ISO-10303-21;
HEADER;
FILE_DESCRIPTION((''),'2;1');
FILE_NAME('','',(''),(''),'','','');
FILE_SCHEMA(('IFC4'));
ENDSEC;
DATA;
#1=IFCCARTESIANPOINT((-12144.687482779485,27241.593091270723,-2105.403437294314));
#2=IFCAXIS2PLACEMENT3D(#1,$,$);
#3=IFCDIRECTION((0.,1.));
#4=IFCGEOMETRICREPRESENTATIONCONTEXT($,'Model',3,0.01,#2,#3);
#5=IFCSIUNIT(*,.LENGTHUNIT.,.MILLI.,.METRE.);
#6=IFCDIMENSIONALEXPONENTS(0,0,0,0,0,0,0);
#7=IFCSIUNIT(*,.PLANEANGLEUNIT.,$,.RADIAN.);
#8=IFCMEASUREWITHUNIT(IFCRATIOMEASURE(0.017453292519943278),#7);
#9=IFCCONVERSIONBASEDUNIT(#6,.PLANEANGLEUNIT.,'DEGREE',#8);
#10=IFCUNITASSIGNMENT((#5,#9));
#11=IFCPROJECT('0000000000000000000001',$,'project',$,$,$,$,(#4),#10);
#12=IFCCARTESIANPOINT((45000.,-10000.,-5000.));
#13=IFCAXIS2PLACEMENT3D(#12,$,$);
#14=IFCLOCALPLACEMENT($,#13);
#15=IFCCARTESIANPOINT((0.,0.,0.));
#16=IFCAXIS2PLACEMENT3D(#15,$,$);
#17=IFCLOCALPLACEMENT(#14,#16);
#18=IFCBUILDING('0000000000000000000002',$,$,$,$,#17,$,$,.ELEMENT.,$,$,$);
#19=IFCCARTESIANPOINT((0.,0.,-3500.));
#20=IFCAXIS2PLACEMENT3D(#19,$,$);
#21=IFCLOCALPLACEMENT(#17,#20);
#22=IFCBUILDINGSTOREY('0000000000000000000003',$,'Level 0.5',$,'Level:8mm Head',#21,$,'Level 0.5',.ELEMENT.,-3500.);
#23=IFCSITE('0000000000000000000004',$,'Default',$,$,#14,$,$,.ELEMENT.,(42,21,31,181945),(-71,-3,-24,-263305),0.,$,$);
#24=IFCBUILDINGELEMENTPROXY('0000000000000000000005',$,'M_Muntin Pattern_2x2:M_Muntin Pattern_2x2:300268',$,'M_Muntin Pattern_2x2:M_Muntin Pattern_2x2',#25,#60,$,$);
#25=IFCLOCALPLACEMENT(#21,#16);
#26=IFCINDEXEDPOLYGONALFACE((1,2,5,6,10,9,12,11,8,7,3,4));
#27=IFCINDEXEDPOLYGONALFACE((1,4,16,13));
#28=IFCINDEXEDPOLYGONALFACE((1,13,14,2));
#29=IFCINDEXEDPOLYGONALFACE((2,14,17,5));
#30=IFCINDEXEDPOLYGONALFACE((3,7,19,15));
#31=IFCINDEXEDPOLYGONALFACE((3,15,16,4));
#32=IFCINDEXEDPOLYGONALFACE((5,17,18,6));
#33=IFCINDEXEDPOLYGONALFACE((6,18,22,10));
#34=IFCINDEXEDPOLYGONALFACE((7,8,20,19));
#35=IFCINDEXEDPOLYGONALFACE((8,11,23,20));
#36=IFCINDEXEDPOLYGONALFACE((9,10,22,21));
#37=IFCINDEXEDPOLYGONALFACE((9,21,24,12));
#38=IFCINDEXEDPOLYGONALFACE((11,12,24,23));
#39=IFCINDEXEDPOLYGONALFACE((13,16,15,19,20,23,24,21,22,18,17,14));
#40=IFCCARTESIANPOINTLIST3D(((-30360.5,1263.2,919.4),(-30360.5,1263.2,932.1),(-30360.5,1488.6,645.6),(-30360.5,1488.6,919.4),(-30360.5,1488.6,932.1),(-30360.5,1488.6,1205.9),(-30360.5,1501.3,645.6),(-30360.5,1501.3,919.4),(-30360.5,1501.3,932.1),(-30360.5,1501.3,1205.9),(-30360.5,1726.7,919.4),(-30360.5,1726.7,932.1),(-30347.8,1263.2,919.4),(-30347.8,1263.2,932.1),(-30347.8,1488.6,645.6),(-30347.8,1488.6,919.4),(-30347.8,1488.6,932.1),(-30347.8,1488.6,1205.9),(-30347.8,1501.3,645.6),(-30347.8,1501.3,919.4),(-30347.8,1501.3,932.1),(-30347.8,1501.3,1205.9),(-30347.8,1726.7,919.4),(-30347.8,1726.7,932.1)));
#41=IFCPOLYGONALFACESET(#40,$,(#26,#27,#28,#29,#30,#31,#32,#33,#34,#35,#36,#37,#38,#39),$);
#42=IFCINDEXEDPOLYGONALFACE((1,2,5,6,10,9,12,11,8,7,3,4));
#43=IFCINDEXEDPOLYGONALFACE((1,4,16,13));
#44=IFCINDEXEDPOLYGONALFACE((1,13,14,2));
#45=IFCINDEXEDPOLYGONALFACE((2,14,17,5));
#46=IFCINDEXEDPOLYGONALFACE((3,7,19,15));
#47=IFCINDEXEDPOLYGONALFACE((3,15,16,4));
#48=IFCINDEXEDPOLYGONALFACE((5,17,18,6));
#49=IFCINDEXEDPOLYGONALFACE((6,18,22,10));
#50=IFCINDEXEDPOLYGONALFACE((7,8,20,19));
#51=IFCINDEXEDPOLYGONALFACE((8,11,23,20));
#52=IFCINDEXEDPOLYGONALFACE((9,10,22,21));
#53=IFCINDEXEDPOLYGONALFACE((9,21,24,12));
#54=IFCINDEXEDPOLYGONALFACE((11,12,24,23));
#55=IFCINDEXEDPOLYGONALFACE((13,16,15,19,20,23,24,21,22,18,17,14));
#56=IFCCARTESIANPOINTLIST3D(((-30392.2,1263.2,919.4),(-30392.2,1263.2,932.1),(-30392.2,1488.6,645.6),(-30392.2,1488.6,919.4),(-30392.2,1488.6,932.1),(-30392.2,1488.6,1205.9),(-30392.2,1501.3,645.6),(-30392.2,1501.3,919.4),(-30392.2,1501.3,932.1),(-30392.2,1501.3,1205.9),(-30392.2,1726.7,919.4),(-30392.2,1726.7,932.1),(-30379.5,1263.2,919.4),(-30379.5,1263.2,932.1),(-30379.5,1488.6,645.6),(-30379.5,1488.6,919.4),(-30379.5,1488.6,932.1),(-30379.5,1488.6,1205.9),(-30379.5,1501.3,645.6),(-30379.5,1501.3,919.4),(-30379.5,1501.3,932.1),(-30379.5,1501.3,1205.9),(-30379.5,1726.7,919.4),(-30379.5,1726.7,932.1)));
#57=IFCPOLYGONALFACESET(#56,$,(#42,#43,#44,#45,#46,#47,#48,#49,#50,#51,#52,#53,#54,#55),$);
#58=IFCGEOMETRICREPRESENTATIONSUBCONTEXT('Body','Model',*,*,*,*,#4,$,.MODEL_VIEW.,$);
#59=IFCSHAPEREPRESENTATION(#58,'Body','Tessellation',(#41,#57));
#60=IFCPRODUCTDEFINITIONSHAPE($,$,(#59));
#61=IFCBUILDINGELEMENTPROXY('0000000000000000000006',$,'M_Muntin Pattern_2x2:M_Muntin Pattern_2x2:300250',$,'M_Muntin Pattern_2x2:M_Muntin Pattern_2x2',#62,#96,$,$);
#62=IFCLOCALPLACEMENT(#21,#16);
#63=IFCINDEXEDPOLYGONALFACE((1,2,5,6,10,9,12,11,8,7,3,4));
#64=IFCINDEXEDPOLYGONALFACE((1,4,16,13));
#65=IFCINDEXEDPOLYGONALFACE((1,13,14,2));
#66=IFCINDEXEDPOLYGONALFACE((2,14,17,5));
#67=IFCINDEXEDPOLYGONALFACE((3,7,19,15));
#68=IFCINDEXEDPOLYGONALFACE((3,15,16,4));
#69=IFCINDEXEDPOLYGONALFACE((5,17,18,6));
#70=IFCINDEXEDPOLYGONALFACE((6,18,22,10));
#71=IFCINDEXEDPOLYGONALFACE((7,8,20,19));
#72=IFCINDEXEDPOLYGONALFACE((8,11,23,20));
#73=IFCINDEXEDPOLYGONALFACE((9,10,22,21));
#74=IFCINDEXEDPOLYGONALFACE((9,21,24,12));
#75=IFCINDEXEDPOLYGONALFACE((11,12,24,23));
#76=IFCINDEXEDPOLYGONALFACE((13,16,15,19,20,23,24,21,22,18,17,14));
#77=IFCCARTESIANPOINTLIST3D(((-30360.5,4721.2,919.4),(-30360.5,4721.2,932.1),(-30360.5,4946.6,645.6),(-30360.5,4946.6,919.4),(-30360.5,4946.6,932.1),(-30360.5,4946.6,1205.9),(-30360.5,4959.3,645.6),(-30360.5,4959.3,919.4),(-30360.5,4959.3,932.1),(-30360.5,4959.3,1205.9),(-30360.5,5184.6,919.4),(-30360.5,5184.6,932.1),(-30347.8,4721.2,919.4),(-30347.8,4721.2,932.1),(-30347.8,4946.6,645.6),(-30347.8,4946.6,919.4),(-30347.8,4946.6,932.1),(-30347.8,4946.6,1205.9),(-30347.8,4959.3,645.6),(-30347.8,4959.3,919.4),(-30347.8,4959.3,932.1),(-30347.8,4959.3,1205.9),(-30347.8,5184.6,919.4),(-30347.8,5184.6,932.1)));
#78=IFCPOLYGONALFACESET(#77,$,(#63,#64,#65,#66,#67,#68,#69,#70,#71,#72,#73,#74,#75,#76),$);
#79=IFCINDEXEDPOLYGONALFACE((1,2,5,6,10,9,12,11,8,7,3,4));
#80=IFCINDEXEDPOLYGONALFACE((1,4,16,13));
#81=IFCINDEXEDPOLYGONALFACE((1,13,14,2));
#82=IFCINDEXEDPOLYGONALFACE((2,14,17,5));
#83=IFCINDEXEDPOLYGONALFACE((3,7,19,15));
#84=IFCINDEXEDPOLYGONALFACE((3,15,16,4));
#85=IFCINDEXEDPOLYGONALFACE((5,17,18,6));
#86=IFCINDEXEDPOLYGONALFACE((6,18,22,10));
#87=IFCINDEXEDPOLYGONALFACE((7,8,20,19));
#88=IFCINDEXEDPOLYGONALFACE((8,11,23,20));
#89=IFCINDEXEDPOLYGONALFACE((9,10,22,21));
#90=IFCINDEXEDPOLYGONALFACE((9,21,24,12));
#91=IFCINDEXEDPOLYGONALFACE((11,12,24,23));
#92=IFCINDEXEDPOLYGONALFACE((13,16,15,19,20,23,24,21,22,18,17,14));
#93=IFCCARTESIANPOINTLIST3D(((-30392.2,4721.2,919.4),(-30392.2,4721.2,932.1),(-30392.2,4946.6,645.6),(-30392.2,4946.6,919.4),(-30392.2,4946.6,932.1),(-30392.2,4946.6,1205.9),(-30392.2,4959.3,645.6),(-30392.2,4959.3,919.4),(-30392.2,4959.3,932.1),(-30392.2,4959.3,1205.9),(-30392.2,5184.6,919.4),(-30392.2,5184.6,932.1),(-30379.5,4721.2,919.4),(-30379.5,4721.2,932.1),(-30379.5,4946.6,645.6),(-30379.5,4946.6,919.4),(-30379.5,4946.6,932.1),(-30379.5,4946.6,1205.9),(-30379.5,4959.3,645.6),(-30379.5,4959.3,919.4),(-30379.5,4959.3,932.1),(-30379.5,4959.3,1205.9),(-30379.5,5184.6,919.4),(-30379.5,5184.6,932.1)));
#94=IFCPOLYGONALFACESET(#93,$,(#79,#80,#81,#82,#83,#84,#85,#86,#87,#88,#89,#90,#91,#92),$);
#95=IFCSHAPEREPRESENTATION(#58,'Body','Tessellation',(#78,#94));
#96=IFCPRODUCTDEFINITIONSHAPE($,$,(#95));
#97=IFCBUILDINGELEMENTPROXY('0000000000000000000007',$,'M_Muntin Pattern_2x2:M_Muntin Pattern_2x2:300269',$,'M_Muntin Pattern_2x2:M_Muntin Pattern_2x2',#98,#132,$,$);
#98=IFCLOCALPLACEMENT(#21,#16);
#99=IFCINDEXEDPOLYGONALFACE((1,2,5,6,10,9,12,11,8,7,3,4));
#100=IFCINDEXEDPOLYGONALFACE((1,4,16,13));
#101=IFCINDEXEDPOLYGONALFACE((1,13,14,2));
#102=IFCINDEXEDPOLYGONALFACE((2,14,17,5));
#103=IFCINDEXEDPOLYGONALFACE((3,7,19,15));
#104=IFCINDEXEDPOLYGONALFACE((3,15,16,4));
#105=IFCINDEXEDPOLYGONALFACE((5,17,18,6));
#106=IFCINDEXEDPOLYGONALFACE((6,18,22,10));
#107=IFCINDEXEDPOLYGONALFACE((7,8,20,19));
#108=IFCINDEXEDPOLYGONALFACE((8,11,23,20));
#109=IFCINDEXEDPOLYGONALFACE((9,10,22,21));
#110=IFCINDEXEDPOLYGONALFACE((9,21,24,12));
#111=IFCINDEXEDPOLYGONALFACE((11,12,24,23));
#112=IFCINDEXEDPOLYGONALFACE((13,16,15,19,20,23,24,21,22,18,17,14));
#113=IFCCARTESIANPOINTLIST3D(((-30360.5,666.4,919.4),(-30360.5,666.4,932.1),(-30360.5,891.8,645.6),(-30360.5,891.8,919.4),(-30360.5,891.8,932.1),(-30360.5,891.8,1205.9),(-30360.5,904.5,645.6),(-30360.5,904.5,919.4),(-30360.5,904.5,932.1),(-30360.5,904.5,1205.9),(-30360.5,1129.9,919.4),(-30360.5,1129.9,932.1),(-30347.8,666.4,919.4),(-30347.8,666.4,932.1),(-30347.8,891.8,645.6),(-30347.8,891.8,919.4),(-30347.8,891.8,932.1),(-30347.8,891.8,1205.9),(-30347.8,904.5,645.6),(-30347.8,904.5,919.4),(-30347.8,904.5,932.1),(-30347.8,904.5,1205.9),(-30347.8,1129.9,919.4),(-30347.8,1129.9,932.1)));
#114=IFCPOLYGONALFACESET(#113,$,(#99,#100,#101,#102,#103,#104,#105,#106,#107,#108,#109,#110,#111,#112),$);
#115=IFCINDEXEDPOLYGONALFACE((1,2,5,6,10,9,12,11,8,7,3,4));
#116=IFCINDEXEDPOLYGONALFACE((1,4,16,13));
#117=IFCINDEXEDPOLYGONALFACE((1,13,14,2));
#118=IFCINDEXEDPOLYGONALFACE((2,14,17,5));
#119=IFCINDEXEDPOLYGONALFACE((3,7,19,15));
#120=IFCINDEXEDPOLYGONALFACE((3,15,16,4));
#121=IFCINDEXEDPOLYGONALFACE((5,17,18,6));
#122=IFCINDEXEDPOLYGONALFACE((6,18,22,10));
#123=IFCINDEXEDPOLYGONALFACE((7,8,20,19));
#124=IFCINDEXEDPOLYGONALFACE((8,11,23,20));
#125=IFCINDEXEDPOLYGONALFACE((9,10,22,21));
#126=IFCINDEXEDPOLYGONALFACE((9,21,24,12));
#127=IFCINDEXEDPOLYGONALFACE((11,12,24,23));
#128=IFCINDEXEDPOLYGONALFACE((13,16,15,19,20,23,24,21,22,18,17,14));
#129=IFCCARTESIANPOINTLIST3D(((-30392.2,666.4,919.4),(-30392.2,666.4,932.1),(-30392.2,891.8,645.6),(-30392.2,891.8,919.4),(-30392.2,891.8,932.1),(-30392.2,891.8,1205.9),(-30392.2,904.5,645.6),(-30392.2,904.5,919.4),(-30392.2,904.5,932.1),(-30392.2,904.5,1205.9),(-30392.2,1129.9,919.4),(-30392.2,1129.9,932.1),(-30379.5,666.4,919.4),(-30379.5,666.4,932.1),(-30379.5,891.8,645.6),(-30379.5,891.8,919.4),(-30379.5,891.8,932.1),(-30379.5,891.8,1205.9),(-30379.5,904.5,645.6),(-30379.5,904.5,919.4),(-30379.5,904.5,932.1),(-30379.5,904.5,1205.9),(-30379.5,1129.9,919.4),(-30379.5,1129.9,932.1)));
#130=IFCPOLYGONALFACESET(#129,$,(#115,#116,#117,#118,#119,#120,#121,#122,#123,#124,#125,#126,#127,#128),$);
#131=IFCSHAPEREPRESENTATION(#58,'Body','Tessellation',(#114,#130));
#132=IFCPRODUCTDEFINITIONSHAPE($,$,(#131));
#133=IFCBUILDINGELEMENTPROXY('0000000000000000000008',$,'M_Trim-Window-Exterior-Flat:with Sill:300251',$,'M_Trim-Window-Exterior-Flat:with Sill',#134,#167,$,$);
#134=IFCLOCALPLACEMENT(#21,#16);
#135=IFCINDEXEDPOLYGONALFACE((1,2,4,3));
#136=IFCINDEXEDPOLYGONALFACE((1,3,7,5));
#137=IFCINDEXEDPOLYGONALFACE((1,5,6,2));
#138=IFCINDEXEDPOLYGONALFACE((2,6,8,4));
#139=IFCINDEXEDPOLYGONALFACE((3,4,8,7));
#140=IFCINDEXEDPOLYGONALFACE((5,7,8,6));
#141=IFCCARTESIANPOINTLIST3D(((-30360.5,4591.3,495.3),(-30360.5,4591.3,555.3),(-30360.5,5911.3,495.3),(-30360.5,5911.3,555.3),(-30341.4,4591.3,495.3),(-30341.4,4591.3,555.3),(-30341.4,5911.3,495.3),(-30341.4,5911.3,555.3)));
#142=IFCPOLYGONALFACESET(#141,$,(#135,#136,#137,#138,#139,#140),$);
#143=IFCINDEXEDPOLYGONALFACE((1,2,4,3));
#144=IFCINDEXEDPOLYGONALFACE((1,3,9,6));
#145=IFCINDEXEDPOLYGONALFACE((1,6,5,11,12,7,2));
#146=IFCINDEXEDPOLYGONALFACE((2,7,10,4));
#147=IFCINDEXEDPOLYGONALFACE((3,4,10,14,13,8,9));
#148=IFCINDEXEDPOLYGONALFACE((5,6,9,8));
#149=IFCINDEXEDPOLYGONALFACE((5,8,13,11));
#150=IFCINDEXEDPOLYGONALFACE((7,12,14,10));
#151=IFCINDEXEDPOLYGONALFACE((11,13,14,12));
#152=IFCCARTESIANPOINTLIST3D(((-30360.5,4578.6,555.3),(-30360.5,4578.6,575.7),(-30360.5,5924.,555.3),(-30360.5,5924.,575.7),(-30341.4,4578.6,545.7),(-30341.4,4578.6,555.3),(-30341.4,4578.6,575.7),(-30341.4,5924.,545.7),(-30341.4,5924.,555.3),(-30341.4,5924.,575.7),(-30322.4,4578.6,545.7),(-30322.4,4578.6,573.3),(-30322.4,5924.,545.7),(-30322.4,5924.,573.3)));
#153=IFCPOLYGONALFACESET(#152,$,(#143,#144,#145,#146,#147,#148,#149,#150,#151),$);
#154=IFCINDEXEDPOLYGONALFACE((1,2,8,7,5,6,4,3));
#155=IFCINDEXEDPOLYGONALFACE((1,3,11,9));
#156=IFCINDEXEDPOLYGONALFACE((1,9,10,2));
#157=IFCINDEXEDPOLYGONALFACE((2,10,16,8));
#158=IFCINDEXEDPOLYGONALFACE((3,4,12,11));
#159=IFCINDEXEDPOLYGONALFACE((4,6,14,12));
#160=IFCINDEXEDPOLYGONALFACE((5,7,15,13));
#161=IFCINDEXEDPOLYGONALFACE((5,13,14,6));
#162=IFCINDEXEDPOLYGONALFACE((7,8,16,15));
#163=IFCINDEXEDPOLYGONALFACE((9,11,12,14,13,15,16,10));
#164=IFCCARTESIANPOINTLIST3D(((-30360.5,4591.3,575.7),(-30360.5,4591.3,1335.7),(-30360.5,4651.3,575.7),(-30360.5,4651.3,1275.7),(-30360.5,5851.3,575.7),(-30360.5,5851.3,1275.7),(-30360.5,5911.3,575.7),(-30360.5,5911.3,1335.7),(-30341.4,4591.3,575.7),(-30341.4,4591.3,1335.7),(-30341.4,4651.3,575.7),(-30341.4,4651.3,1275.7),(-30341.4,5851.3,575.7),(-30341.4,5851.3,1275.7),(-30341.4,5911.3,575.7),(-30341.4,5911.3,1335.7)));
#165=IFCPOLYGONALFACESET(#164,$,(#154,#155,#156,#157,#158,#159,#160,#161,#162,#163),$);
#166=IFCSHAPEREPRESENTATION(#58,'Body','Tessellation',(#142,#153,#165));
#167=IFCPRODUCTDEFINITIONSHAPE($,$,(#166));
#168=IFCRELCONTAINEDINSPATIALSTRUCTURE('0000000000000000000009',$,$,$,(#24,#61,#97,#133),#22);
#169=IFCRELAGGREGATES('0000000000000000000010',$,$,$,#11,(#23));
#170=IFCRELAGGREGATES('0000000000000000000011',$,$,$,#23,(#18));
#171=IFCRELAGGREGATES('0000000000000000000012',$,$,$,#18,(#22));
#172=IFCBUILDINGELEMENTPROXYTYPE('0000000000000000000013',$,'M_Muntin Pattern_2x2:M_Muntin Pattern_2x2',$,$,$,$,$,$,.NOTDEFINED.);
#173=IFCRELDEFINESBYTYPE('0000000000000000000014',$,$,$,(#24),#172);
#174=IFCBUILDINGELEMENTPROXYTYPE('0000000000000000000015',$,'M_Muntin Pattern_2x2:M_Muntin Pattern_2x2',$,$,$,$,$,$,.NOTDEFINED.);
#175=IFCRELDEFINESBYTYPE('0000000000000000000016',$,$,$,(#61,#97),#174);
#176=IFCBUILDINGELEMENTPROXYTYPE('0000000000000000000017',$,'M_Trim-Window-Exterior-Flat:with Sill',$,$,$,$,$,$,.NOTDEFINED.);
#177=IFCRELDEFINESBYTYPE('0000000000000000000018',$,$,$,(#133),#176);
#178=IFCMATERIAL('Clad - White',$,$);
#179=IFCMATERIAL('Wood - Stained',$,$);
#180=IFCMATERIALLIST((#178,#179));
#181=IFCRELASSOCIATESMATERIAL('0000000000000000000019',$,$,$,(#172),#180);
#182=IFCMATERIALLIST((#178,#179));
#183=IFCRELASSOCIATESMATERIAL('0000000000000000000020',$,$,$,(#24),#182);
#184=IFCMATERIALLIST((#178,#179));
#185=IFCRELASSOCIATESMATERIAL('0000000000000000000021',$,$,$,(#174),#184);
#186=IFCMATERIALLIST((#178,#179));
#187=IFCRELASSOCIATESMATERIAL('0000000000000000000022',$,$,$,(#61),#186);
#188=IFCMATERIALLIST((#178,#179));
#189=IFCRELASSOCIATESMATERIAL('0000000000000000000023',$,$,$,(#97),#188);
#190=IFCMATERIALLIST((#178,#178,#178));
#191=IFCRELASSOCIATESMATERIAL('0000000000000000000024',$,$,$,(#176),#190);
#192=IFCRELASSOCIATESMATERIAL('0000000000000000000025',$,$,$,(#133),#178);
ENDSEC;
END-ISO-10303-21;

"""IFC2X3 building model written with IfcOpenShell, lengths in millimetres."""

from ifc_helpers import new_model, entity, si_unit, converted_unit, direction, frame, frame_2d, origin, place, context, subcontext, project, spatial, polyline, rectangle, outline, extrude, source, transform, mapped, material, material_list, type_object, type_shapes, element, save


model = new_model("IFC2X3")

# Units and contexts
model_context = context("Model", 3, precision=0.01, world=frame((-12144.687482779485, 27241.593091270723, -2105.403437294314)), true_north=direction((0.0, 1.0)))
body_context = subcontext(model_context, "Body", "Model", "MODEL_VIEW")
ifc_project = project(units=[si_unit("LENGTHUNIT", "METRE", prefix="MILLI"), converted_unit("PLANEANGLEUNIT", "DEGREE", entity("IfcRatioMeasure", 0.017453292519943278), si_unit("PLANEANGLEUNIT", "RADIAN"), dimensions=[0, 0, 0, 0, 0, 0, 0])], contexts=[model_context])

# Site, building, storey
site_placement = place(None, frame((45000.0, -10000.0, -5000.0)))
site = spatial("IfcSite", under=ifc_project, at=site_placement, Name="Default", CompositionType="ELEMENT", RefLatitude=(42, 21, 31, 181945), RefLongitude=(-71, -3, -24, -263305), RefElevation=0.0)
building_placement = place(site_placement, origin())
building = spatial("IfcBuilding", under=site, at=building_placement, CompositionType="ELEMENT")
storey_placement = place(building_placement, frame((0.0, 0.0, -3500.0)))
storey = spatial("IfcBuildingStorey", under=building, at=storey_placement, Name="Level 0.5", ObjectType="Level:8mm Head", LongName="Level 0.5", CompositionType="ELEMENT", Elevation=-3500.0)

# Building element proxies
ifc_material_1 = material(Name="Clad - White")
ifc_material_2 = material(Name="Wood - Stained")
ifc_material_list_1 = material_list([ifc_material_1, ifc_material_2])
ifc_material_list_2 = material_list([ifc_material_1, ifc_material_2])
building_element_proxy_type_1 = type_object("IfcBuildingElementProxyType", Name="M_Muntin Pattern_2x2:M_Muntin Pattern_2x2", PredefinedType="NOTDEFINED", material=ifc_material_list_2)
shared_shape_1 = source(origin(), body_context, "Body", "SweptSolid", [
    extrude(outline(polyline([(6.4, -6.4), (280.1, -6.4), (280.1, 6.3), (6.4, 6.3), (6.4, 231.7), (-6.3, 231.7), (-6.3, 6.3), (-280.2, 6.3), (-280.2, -6.4), (-6.3, -6.4), (-6.3, -231.7), (6.4, -231.7), (6.4, -6.4)])), frame((0.0, 9.5, 280.1), z_axis=(0.0, 1.0, 0.0), x_axis=(0.0, 0.0, 1.0)), (0.0, 0.0, 1.0), 12.7),
    extrude(outline(polyline([(6.4, -6.4), (280.2, -6.4), (280.2, 6.3), (6.4, 6.3), (6.4, 231.7), (-6.3, 231.7), (-6.3, 6.3), (-280.2, 6.3), (-280.2, -6.4), (-6.3, -6.4), (-6.3, -231.7), (6.4, -231.7), (6.4, -6.4)])), frame((0.0, -22.2, 280.2), z_axis=(0.0, 1.0, 0.0), x_axis=(0.0, 0.0, 1.0)), (0.0, 0.0, 1.0), 12.7),
])
type_shapes(building_element_proxy_type_1, [shared_shape_1])
proxy_1_placement = place(storey_placement, frame((-30370.0, 1495.0, 645.6), z_axis=(0.0, 0.0, 1.0), x_axis=(0.0, -1.0, 0.0)))
element("IfcBuildingElementProxy", 1, at=proxy_1_placement, inside=storey, type_object=building_element_proxy_type_1, material=ifc_material_list_1, Name="M_Muntin Pattern_2x2:M_Muntin Pattern_2x2:300268", ObjectType="M_Muntin Pattern_2x2:M_Muntin Pattern_2x2", context=body_context, shape_type="MappedRepresentation", body=[
    mapped(shared_shape_1, transform((0.0, 0.0, 0.0), scale=1.0)),
])
ifc_material_list_3 = material_list([ifc_material_1, ifc_material_2])
ifc_material_list_4 = material_list([ifc_material_1, ifc_material_2])
building_element_proxy_type_2 = type_object("IfcBuildingElementProxyType", Name="M_Muntin Pattern_2x2:M_Muntin Pattern_2x2", PredefinedType="NOTDEFINED", material=ifc_material_list_4)
shared_shape_2 = source(origin(), body_context, "Body", "SweptSolid", [
    extrude(outline(polyline([(6.4, -6.4), (280.1, -6.4), (280.1, 6.3), (6.4, 6.3), (6.4, 231.7), (-6.3, 231.7), (-6.3, 6.3), (-280.2, 6.3), (-280.2, -6.4), (-6.3, -6.4), (-6.3, -231.7), (6.4, -231.7), (6.4, -6.4)])), frame((0.0, -22.2, 280.1), z_axis=(0.0, 1.0, 0.0), x_axis=(0.0, 0.0, 1.0)), (0.0, 0.0, 1.0), 12.7),
    extrude(outline(polyline([(6.4, -6.4), (280.2, -6.4), (280.2, 6.3), (6.4, 6.3), (6.4, 231.7), (-6.3, 231.7), (-6.3, 6.3), (-280.2, 6.3), (-280.2, -6.4), (-6.3, -6.4), (-6.3, -231.7), (6.4, -231.7), (6.4, -6.4)])), frame((0.0, 9.5, 280.2), z_axis=(0.0, 1.0, 0.0), x_axis=(0.0, 0.0, 1.0)), (0.0, 0.0, 1.0), 12.7),
])
type_shapes(building_element_proxy_type_2, [shared_shape_2])
proxy_2_placement = place(storey_placement, frame((-30370.0, 4952.9, 645.6), z_axis=(0.0, 0.0, 1.0), x_axis=(0.0, 1.0, 0.0)))
element("IfcBuildingElementProxy", 2, at=proxy_2_placement, inside=storey, type_object=building_element_proxy_type_2, material=ifc_material_list_3, Name="M_Muntin Pattern_2x2:M_Muntin Pattern_2x2:300250", ObjectType="M_Muntin Pattern_2x2:M_Muntin Pattern_2x2", context=body_context, shape_type="MappedRepresentation", body=[
    mapped(shared_shape_2, transform((0.0, 0.0, 0.0), scale=1.0)),
])
ifc_material_list_5 = material_list([ifc_material_1, ifc_material_2])
proxy_3_placement = place(storey_placement, frame((-30370.0, 898.1, 645.6), z_axis=(0.0, 0.0, 1.0), x_axis=(0.0, 1.0, 0.0)))
element("IfcBuildingElementProxy", 3, at=proxy_3_placement, inside=storey, type_object=building_element_proxy_type_2, material=ifc_material_list_5, Name="M_Muntin Pattern_2x2:M_Muntin Pattern_2x2:300269", ObjectType="M_Muntin Pattern_2x2:M_Muntin Pattern_2x2", context=body_context, shape_type="MappedRepresentation", body=[
    mapped(shared_shape_2, transform((0.0, 0.0, 0.0), scale=1.0)),
])
ifc_material_list_6 = material_list([ifc_material_1, ifc_material_1, ifc_material_1])
building_element_proxy_type_3 = type_object("IfcBuildingElementProxyType", Name="M_Trim-Window-Exterior-Flat:with Sill", PredefinedType="NOTDEFINED", material=ifc_material_list_6)
shared_shape_3 = source(origin(), body_context, "Body", "SweptSolid", [
    extrude(rectangle(XDim=1320.0, YDim=60.0, at=frame_2d((0.0, 0.0), x_axis=(1.0, 0.0))), frame((0.0, -750.4, 0.0), z_axis=(0.0, 0.0, 1.0), x_axis=(-1.0, 0.0, 0.0)), (0.0, 0.0, 1.0), 19.0),
    extrude(outline(polyline([(-19.0, -15.2), (0.0, -15.2), (0.0, -5.7), (19.0, -5.7), (19.0, 14.8), (0.0, 14.8), (-19.0, 12.3), (-19.0, -15.2)])), frame((-672.7, -714.8, 19.0), z_axis=(1.0, 0.0, 0.0), x_axis=(0.0, 0.0, -1.0)), (0.0, 0.0, 1.0), 1345.4),
    extrude(outline(polyline([(-395.0, -660.0), (365.0, -660.0), (365.0, -600.0), (-335.0, -600.0), (-335.0, 600.0), (365.0, 600.0), (365.0, 660.0), (-395.0, 660.0), (-395.0, -660.0)])), frame((0.0, -335.0, 0.0), z_axis=(0.0, 0.0, 1.0), x_axis=(0.0, -1.0, 0.0)), (0.0, 0.0, 1.0), 19.0),
])
type_shapes(building_element_proxy_type_3, [shared_shape_3])
for number, where, z_axis, x_axis, name in (
    (4, (-30360.5, 5251.3, 1275.7), (1.0, 0.0, 0.0), (0.0, 1.0, 0.0), "M_Trim-Window-Exterior-Flat:with Sill:300251"),
):
    element("IfcBuildingElementProxy", number, at=place(storey_placement, frame(where, z_axis=z_axis, x_axis=x_axis)), inside=storey, type_object=building_element_proxy_type_3, material=ifc_material_1, Name=name, ObjectType="M_Trim-Window-Exterior-Flat:with Sill", context=body_context, shape_type="MappedRepresentation", body=[
        mapped(shared_shape_3, transform((0.0, 0.0, 0.0), scale=1.0)),
    ])

save(model, "model.ifc")
